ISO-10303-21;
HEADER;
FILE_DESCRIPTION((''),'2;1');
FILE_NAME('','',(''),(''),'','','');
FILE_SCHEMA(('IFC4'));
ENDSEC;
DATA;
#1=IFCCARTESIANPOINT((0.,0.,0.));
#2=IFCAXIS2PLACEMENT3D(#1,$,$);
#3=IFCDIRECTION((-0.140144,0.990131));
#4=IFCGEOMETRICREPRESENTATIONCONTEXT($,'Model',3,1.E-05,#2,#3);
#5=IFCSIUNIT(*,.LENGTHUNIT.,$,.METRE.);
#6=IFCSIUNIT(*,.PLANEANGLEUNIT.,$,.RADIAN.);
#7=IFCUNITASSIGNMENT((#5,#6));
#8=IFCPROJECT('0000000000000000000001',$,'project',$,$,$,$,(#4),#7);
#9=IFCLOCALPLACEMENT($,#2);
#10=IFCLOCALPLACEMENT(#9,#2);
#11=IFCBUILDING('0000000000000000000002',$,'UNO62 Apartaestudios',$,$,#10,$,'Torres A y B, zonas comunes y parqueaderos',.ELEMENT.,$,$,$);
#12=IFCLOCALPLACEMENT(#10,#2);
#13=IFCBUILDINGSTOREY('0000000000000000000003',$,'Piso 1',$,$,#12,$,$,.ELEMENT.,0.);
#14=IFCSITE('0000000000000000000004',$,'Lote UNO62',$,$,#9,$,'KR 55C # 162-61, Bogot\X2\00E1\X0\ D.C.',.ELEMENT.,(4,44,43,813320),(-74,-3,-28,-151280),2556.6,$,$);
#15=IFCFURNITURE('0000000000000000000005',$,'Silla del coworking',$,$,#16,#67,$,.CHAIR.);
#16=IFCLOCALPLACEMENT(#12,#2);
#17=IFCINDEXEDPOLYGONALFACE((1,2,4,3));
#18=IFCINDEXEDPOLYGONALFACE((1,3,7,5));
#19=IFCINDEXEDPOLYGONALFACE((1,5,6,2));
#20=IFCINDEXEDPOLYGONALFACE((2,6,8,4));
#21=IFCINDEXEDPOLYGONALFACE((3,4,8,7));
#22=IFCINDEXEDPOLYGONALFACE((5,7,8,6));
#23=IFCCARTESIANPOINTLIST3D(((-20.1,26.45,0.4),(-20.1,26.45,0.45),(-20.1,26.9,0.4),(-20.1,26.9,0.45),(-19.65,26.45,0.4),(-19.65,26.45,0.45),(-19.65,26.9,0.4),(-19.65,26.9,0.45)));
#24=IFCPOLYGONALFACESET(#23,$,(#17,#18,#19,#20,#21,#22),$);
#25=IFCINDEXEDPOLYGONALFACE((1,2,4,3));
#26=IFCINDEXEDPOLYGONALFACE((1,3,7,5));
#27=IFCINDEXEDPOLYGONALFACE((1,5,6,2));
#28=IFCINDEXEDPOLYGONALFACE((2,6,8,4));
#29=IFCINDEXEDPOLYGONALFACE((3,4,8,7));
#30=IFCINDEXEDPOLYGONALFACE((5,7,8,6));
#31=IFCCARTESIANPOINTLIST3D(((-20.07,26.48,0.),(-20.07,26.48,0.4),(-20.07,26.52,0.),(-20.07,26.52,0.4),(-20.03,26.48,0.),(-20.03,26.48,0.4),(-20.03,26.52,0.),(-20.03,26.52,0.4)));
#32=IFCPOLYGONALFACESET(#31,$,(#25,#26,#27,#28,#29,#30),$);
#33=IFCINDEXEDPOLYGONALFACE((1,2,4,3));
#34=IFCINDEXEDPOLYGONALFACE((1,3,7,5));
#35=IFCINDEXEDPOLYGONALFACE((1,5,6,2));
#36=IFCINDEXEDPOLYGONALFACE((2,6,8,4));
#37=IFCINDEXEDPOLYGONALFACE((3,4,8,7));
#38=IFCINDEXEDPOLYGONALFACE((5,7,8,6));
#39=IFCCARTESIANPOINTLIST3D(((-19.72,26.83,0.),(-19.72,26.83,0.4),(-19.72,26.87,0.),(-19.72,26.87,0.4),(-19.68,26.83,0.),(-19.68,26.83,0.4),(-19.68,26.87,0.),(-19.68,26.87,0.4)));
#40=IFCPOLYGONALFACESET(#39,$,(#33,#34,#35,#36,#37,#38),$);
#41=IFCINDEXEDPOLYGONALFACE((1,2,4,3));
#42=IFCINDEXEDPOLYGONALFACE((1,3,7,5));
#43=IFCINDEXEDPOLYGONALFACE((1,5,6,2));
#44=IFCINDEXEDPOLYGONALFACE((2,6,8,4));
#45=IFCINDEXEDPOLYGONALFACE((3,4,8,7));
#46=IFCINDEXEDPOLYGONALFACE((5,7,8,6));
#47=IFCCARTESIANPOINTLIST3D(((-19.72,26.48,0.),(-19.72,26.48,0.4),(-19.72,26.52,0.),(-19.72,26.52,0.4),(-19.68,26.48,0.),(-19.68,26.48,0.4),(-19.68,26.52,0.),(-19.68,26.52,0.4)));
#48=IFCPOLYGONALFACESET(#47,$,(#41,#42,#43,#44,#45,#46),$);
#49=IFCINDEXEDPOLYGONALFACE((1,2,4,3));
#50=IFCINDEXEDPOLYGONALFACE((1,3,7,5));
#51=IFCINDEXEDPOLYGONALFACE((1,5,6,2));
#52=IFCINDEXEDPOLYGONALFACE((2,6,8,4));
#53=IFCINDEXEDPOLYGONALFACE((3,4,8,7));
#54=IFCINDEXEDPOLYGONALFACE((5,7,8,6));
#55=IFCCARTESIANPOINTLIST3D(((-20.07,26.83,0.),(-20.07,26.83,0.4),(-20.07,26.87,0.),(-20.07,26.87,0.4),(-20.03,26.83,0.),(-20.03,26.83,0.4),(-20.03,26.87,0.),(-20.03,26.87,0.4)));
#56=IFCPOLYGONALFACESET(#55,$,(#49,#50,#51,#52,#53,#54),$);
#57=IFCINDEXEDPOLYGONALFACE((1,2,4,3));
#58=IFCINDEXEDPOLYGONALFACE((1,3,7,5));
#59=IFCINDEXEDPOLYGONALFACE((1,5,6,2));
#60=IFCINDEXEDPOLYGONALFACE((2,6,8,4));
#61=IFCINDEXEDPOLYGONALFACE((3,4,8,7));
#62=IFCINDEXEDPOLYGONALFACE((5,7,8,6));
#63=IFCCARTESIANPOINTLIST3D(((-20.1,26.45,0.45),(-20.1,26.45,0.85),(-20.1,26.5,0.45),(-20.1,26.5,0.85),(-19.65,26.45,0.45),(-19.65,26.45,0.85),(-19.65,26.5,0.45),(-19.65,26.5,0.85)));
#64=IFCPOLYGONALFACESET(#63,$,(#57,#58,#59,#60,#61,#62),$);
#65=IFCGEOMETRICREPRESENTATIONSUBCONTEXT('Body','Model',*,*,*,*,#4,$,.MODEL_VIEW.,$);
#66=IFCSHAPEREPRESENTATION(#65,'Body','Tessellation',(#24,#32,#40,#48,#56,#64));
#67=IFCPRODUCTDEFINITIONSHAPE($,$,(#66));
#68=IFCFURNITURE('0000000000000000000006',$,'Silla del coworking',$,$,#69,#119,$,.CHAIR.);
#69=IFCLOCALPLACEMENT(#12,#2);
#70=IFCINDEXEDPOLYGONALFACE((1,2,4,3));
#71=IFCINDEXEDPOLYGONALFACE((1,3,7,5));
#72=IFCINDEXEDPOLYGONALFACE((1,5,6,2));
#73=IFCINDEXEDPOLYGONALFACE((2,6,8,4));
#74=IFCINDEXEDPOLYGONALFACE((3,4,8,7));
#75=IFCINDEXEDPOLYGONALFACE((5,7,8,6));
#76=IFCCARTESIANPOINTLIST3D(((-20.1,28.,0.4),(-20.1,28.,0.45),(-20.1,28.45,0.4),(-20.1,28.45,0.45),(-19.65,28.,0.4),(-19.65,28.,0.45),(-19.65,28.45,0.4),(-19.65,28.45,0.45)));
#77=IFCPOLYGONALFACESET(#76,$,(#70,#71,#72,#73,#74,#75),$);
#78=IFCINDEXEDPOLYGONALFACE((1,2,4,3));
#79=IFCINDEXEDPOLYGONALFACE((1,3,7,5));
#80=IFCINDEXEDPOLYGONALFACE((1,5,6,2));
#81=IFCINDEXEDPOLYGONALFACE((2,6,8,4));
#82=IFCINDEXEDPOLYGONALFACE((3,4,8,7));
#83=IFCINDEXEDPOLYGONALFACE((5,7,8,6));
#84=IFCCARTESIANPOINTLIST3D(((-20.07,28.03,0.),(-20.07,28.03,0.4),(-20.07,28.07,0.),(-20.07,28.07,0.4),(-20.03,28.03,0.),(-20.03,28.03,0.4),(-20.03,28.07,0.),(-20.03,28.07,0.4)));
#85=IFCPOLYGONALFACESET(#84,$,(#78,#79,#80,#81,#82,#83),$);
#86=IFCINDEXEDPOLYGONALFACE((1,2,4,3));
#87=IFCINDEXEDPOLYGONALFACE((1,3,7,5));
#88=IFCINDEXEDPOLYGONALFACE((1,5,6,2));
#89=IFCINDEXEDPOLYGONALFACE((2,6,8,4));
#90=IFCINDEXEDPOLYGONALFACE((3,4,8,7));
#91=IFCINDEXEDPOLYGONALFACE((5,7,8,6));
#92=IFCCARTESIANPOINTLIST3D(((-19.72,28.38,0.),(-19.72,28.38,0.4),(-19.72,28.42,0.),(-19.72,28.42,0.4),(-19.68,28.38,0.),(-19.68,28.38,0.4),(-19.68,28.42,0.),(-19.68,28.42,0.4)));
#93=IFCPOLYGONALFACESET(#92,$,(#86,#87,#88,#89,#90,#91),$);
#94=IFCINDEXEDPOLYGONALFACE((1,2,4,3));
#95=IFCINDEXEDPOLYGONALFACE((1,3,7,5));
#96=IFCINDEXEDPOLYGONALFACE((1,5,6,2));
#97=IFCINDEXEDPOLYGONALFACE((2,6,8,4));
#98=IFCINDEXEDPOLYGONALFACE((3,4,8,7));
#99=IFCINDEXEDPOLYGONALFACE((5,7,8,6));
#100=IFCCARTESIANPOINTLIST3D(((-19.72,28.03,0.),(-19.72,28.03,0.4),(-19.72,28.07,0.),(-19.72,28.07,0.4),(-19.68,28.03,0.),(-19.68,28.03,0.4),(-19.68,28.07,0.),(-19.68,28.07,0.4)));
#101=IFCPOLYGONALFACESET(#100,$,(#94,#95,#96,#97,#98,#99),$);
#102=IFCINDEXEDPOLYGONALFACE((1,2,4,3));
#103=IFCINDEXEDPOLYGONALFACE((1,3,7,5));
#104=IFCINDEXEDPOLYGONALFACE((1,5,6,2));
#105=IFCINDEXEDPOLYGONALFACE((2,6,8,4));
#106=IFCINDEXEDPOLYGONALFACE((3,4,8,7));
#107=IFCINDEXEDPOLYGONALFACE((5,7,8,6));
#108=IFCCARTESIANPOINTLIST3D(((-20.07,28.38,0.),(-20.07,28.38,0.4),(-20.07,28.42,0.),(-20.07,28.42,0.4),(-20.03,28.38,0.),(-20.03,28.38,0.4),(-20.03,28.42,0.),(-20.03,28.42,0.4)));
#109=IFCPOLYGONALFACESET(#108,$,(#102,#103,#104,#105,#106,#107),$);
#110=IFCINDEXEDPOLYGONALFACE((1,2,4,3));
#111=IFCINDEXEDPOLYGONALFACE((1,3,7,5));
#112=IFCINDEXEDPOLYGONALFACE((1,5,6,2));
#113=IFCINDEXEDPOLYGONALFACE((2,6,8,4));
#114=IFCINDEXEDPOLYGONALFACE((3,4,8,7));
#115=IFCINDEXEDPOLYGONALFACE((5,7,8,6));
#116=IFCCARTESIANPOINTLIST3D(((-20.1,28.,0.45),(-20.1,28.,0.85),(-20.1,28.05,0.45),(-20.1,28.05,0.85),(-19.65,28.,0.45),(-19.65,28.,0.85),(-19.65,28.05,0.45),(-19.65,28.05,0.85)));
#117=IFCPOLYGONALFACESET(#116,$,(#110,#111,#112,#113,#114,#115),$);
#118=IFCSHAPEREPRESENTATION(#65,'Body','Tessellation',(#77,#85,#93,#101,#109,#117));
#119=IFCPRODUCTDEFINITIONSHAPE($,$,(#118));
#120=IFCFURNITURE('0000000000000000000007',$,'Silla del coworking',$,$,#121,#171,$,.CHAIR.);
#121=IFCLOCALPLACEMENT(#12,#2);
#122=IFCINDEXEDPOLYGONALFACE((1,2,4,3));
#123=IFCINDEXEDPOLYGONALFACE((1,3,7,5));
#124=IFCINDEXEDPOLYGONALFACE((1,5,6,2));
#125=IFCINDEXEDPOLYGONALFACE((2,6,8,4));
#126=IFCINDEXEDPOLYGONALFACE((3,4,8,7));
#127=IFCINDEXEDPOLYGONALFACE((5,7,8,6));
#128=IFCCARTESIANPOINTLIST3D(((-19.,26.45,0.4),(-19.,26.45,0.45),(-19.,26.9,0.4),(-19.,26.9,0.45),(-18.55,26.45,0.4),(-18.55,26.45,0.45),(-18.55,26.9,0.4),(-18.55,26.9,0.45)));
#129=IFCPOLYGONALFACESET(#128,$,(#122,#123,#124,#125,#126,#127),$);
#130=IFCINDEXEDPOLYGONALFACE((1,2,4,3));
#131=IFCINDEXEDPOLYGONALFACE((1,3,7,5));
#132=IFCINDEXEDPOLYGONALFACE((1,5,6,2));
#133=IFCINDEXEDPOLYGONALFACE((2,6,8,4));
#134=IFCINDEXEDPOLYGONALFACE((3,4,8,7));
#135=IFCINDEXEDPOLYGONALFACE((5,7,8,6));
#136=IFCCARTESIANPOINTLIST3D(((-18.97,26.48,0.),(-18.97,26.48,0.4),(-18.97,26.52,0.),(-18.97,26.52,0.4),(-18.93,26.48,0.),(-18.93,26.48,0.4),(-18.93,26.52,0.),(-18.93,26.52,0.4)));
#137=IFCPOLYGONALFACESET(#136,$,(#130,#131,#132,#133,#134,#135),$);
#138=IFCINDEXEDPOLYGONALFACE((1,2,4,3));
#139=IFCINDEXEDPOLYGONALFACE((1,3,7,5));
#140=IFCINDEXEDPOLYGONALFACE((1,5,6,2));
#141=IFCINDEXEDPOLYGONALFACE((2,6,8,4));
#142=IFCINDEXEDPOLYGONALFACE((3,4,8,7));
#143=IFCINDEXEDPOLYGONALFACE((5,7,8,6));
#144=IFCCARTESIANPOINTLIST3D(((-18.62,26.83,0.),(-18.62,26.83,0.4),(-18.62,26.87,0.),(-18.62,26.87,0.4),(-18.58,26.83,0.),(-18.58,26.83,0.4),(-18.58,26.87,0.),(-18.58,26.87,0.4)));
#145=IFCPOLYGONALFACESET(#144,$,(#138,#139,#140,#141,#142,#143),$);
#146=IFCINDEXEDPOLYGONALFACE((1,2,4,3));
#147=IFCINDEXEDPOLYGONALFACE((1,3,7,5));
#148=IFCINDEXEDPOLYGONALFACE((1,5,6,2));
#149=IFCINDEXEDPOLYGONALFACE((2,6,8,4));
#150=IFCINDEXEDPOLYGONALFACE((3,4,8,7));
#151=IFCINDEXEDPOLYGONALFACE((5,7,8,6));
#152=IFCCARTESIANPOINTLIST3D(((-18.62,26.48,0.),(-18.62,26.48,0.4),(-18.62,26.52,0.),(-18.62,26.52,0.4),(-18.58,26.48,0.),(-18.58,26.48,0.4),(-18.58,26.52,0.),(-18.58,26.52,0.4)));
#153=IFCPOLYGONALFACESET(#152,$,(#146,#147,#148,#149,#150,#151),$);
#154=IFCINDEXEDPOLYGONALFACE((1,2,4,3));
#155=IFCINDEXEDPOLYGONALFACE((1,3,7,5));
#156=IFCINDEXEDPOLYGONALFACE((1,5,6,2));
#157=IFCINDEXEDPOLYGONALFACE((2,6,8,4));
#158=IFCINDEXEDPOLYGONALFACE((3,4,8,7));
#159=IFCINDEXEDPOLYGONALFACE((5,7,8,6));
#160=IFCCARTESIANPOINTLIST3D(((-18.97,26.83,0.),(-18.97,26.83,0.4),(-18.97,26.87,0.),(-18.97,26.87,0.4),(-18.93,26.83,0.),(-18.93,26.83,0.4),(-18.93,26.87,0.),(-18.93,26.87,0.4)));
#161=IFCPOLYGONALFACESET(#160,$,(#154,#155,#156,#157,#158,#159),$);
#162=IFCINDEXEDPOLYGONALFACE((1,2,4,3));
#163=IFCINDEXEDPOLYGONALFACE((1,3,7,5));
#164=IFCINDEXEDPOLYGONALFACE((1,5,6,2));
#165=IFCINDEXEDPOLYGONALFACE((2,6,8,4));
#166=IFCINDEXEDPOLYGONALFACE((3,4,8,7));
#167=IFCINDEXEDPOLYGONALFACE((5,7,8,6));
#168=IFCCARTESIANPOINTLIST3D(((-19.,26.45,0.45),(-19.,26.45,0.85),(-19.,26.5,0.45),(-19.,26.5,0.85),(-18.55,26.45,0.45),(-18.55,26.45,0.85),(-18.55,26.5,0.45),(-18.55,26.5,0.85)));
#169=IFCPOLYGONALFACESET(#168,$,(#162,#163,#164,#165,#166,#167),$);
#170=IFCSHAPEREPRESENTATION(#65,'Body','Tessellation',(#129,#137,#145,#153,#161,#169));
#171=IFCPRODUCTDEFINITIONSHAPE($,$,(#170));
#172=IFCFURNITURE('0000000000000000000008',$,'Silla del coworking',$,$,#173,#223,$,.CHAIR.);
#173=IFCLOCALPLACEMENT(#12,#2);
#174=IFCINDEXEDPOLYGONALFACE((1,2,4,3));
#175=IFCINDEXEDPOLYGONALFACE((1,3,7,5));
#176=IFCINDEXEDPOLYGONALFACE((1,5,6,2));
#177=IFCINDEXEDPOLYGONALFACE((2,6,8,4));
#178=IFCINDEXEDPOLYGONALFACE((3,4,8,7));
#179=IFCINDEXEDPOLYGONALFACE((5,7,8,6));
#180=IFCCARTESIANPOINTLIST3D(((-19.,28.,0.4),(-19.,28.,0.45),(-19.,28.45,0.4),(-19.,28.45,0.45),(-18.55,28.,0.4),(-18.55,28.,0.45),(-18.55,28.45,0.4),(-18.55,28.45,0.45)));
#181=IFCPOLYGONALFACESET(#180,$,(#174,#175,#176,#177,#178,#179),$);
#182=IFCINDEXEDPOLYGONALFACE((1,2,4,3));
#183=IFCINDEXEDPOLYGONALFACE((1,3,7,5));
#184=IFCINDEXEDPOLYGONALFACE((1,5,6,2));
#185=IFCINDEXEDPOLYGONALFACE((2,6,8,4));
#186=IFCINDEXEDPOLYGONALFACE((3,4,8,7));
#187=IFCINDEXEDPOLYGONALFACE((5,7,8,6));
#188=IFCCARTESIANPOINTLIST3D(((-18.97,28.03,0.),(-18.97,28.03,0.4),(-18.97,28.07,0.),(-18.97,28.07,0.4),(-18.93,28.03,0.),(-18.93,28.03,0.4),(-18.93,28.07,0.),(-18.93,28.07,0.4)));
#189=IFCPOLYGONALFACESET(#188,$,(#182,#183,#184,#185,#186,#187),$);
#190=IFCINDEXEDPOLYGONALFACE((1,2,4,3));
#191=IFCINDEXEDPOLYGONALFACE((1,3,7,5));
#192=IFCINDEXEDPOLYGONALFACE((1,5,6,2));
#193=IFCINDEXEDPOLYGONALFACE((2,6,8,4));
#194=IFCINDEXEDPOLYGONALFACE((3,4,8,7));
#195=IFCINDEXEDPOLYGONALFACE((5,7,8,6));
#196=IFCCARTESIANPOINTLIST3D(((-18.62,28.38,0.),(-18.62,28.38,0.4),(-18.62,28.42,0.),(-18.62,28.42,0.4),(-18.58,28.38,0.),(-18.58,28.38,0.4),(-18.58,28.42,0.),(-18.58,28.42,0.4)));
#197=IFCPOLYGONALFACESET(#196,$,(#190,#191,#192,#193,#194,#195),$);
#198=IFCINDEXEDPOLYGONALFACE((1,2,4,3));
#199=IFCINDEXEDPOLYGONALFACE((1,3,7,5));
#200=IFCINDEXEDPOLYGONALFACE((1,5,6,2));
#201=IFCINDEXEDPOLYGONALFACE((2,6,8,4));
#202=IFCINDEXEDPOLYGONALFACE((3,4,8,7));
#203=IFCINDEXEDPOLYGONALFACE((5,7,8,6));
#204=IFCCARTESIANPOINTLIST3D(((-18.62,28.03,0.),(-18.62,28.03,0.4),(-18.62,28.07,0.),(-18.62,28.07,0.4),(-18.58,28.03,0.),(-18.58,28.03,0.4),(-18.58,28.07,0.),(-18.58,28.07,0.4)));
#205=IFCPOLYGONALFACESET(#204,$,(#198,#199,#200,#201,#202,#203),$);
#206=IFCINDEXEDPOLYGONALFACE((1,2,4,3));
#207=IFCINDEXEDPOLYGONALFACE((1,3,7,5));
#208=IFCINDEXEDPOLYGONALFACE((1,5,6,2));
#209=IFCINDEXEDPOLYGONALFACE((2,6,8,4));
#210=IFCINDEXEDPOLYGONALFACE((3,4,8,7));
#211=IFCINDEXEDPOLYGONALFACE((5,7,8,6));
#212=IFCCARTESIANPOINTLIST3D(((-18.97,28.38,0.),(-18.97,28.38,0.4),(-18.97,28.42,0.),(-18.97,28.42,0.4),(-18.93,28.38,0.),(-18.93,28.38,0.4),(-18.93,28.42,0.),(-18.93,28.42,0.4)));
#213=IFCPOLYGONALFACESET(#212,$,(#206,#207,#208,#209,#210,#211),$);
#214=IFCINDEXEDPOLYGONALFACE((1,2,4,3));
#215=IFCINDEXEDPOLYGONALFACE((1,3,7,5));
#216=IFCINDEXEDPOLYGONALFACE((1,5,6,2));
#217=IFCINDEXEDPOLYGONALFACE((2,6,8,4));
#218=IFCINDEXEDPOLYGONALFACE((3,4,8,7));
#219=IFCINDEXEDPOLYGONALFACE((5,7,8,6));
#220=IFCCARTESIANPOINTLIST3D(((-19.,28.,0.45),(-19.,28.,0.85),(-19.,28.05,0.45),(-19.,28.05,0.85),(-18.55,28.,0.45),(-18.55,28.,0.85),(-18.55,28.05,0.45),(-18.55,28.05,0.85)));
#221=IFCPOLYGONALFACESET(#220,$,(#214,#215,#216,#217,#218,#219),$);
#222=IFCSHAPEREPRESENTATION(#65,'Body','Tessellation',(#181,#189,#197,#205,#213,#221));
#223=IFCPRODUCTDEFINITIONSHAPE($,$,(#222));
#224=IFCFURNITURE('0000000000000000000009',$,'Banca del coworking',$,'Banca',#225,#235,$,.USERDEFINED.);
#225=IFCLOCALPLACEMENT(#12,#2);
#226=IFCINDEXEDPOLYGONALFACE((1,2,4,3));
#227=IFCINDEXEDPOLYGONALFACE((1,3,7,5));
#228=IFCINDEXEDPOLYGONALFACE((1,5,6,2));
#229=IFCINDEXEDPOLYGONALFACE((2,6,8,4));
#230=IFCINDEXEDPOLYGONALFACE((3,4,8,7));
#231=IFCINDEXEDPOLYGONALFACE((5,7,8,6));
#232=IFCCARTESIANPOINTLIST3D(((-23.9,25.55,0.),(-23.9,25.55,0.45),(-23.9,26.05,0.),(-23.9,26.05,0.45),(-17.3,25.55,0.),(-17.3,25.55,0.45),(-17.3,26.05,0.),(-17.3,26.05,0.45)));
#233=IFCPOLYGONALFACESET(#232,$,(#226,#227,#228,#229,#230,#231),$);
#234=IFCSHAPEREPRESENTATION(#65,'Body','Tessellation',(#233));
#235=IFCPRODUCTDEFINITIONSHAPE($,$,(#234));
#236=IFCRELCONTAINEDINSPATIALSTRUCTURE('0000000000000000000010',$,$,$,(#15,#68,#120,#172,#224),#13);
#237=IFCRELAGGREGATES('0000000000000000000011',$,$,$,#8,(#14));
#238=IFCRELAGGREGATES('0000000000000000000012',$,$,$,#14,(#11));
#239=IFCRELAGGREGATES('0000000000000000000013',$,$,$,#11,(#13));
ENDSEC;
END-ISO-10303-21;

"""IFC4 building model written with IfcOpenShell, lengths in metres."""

from ifc_helpers import new_model, si_unit, direction, frame, frame_2d, origin, place, context, subcontext, project, spatial, rectangle, extrude, element, save


model = new_model("IFC4")

# Units and contexts
model_context = context("Model", 3, precision=1e-05, world=origin(), true_north=direction((-0.140144, 0.990131)))
body_context = subcontext(model_context, "Body", "Model", "MODEL_VIEW")
ifc_project = project(units=[si_unit("LENGTHUNIT", "METRE"), si_unit("PLANEANGLEUNIT", "RADIAN")], contexts=[model_context])

# Site, building, storey
site_placement = place(None, origin())
site = spatial("IfcSite", under=ifc_project, at=site_placement, Name="Lote UNO62", LongName="KR 55C # 162-61, Bogotá D.C.", CompositionType="ELEMENT", RefLatitude=(4, 44, 43, 813320), RefLongitude=(-74, -3, -28, -151280), RefElevation=2556.6)
building_placement = place(site_placement, origin())
building = spatial("IfcBuilding", under=site, at=building_placement, Name="UNO62 Apartaestudios", LongName="Torres A y B, zonas comunes y parqueaderos", CompositionType="ELEMENT")
storey_placement = place(building_placement, origin())
storey = spatial("IfcBuildingStorey", under=building, at=storey_placement, Name="Piso 1", CompositionType="ELEMENT", Elevation=0.0)

# Furniture
furniture_1_placement = place(storey_placement, origin())
element("IfcFurniture", 1, at=furniture_1_placement, inside=storey, Name="Silla del coworking", PredefinedType="CHAIR", context=body_context, shape_type="SweptSolid", body=[
    extrude(rectangle(XDim=0.45, YDim=0.45, at=frame_2d((-19.875, 26.675))), frame((0.0, 0.0, 0.4)), (0.0, 0.0, 1.0), 0.05),
    extrude(rectangle(XDim=0.04, YDim=0.04, at=frame_2d((-20.05, 26.5))), origin(), (0.0, 0.0, 1.0), 0.4),
    extrude(rectangle(XDim=0.04, YDim=0.04, at=frame_2d((-19.7, 26.85))), origin(), (0.0, 0.0, 1.0), 0.4),
    extrude(rectangle(XDim=0.04, YDim=0.04, at=frame_2d((-19.7, 26.5))), origin(), (0.0, 0.0, 1.0), 0.4),
    extrude(rectangle(XDim=0.04, YDim=0.04, at=frame_2d((-20.05, 26.85))), origin(), (0.0, 0.0, 1.0), 0.4),
    extrude(rectangle(XDim=0.45, YDim=0.05, at=frame_2d((-19.875, 26.475))), frame((0.0, 0.0, 0.45)), (0.0, 0.0, 1.0), 0.4),
])
furniture_2_placement = place(storey_placement, origin())
element("IfcFurniture", 2, at=furniture_2_placement, inside=storey, Name="Silla del coworking", PredefinedType="CHAIR", context=body_context, shape_type="SweptSolid", body=[
    extrude(rectangle(XDim=0.45, YDim=0.45, at=frame_2d((-19.875, 28.225))), frame((0.0, 0.0, 0.4)), (0.0, 0.0, 1.0), 0.05),
    extrude(rectangle(XDim=0.04, YDim=0.04, at=frame_2d((-20.05, 28.05))), origin(), (0.0, 0.0, 1.0), 0.4),
    extrude(rectangle(XDim=0.04, YDim=0.04, at=frame_2d((-19.7, 28.4))), origin(), (0.0, 0.0, 1.0), 0.4),
    extrude(rectangle(XDim=0.04, YDim=0.04, at=frame_2d((-19.7, 28.05))), origin(), (0.0, 0.0, 1.0), 0.4),
    extrude(rectangle(XDim=0.04, YDim=0.04, at=frame_2d((-20.05, 28.4))), origin(), (0.0, 0.0, 1.0), 0.4),
    extrude(rectangle(XDim=0.45, YDim=0.05, at=frame_2d((-19.875, 28.025))), frame((0.0, 0.0, 0.45)), (0.0, 0.0, 1.0), 0.4),
])
furniture_3_placement = place(storey_placement, origin())
element("IfcFurniture", 3, at=furniture_3_placement, inside=storey, Name="Silla del coworking", PredefinedType="CHAIR", context=body_context, shape_type="SweptSolid", body=[
    extrude(rectangle(XDim=0.45, YDim=0.45, at=frame_2d((-18.775, 26.675))), frame((0.0, 0.0, 0.4)), (0.0, 0.0, 1.0), 0.05),
    extrude(rectangle(XDim=0.04, YDim=0.04, at=frame_2d((-18.95, 26.5))), origin(), (0.0, 0.0, 1.0), 0.4),
    extrude(rectangle(XDim=0.04, YDim=0.04, at=frame_2d((-18.6, 26.85))), origin(), (0.0, 0.0, 1.0), 0.4),
    extrude(rectangle(XDim=0.04, YDim=0.04, at=frame_2d((-18.6, 26.5))), origin(), (0.0, 0.0, 1.0), 0.4),
    extrude(rectangle(XDim=0.04, YDim=0.04, at=frame_2d((-18.95, 26.85))), origin(), (0.0, 0.0, 1.0), 0.4),
    extrude(rectangle(XDim=0.45, YDim=0.05, at=frame_2d((-18.775, 26.475))), frame((0.0, 0.0, 0.45)), (0.0, 0.0, 1.0), 0.4),
])
furniture_4_placement = place(storey_placement, origin())
element("IfcFurniture", 4, at=furniture_4_placement, inside=storey, Name="Silla del coworking", PredefinedType="CHAIR", context=body_context, shape_type="SweptSolid", body=[
    extrude(rectangle(XDim=0.45, YDim=0.45, at=frame_2d((-18.775, 28.225))), frame((0.0, 0.0, 0.4)), (0.0, 0.0, 1.0), 0.05),
    extrude(rectangle(XDim=0.04, YDim=0.04, at=frame_2d((-18.95, 28.05))), origin(), (0.0, 0.0, 1.0), 0.4),
    extrude(rectangle(XDim=0.04, YDim=0.04, at=frame_2d((-18.6, 28.4))), origin(), (0.0, 0.0, 1.0), 0.4),
    extrude(rectangle(XDim=0.04, YDim=0.04, at=frame_2d((-18.6, 28.05))), origin(), (0.0, 0.0, 1.0), 0.4),
    extrude(rectangle(XDim=0.04, YDim=0.04, at=frame_2d((-18.95, 28.4))), origin(), (0.0, 0.0, 1.0), 0.4),
    extrude(rectangle(XDim=0.45, YDim=0.05, at=frame_2d((-18.775, 28.025))), frame((0.0, 0.0, 0.45)), (0.0, 0.0, 1.0), 0.4),
])
furniture_5_placement = place(storey_placement, origin())
element("IfcFurniture", 5, at=furniture_5_placement, inside=storey, Name="Banca del coworking", ObjectType="Banca", PredefinedType="USERDEFINED", context=body_context, shape_type="SweptSolid", body=[
    extrude(rectangle(XDim=6.6, YDim=0.5, at=frame_2d((-20.6, 25.8))), origin(), (0.0, 0.0, 1.0), 0.45),
])

save(model, "model.ifc")
